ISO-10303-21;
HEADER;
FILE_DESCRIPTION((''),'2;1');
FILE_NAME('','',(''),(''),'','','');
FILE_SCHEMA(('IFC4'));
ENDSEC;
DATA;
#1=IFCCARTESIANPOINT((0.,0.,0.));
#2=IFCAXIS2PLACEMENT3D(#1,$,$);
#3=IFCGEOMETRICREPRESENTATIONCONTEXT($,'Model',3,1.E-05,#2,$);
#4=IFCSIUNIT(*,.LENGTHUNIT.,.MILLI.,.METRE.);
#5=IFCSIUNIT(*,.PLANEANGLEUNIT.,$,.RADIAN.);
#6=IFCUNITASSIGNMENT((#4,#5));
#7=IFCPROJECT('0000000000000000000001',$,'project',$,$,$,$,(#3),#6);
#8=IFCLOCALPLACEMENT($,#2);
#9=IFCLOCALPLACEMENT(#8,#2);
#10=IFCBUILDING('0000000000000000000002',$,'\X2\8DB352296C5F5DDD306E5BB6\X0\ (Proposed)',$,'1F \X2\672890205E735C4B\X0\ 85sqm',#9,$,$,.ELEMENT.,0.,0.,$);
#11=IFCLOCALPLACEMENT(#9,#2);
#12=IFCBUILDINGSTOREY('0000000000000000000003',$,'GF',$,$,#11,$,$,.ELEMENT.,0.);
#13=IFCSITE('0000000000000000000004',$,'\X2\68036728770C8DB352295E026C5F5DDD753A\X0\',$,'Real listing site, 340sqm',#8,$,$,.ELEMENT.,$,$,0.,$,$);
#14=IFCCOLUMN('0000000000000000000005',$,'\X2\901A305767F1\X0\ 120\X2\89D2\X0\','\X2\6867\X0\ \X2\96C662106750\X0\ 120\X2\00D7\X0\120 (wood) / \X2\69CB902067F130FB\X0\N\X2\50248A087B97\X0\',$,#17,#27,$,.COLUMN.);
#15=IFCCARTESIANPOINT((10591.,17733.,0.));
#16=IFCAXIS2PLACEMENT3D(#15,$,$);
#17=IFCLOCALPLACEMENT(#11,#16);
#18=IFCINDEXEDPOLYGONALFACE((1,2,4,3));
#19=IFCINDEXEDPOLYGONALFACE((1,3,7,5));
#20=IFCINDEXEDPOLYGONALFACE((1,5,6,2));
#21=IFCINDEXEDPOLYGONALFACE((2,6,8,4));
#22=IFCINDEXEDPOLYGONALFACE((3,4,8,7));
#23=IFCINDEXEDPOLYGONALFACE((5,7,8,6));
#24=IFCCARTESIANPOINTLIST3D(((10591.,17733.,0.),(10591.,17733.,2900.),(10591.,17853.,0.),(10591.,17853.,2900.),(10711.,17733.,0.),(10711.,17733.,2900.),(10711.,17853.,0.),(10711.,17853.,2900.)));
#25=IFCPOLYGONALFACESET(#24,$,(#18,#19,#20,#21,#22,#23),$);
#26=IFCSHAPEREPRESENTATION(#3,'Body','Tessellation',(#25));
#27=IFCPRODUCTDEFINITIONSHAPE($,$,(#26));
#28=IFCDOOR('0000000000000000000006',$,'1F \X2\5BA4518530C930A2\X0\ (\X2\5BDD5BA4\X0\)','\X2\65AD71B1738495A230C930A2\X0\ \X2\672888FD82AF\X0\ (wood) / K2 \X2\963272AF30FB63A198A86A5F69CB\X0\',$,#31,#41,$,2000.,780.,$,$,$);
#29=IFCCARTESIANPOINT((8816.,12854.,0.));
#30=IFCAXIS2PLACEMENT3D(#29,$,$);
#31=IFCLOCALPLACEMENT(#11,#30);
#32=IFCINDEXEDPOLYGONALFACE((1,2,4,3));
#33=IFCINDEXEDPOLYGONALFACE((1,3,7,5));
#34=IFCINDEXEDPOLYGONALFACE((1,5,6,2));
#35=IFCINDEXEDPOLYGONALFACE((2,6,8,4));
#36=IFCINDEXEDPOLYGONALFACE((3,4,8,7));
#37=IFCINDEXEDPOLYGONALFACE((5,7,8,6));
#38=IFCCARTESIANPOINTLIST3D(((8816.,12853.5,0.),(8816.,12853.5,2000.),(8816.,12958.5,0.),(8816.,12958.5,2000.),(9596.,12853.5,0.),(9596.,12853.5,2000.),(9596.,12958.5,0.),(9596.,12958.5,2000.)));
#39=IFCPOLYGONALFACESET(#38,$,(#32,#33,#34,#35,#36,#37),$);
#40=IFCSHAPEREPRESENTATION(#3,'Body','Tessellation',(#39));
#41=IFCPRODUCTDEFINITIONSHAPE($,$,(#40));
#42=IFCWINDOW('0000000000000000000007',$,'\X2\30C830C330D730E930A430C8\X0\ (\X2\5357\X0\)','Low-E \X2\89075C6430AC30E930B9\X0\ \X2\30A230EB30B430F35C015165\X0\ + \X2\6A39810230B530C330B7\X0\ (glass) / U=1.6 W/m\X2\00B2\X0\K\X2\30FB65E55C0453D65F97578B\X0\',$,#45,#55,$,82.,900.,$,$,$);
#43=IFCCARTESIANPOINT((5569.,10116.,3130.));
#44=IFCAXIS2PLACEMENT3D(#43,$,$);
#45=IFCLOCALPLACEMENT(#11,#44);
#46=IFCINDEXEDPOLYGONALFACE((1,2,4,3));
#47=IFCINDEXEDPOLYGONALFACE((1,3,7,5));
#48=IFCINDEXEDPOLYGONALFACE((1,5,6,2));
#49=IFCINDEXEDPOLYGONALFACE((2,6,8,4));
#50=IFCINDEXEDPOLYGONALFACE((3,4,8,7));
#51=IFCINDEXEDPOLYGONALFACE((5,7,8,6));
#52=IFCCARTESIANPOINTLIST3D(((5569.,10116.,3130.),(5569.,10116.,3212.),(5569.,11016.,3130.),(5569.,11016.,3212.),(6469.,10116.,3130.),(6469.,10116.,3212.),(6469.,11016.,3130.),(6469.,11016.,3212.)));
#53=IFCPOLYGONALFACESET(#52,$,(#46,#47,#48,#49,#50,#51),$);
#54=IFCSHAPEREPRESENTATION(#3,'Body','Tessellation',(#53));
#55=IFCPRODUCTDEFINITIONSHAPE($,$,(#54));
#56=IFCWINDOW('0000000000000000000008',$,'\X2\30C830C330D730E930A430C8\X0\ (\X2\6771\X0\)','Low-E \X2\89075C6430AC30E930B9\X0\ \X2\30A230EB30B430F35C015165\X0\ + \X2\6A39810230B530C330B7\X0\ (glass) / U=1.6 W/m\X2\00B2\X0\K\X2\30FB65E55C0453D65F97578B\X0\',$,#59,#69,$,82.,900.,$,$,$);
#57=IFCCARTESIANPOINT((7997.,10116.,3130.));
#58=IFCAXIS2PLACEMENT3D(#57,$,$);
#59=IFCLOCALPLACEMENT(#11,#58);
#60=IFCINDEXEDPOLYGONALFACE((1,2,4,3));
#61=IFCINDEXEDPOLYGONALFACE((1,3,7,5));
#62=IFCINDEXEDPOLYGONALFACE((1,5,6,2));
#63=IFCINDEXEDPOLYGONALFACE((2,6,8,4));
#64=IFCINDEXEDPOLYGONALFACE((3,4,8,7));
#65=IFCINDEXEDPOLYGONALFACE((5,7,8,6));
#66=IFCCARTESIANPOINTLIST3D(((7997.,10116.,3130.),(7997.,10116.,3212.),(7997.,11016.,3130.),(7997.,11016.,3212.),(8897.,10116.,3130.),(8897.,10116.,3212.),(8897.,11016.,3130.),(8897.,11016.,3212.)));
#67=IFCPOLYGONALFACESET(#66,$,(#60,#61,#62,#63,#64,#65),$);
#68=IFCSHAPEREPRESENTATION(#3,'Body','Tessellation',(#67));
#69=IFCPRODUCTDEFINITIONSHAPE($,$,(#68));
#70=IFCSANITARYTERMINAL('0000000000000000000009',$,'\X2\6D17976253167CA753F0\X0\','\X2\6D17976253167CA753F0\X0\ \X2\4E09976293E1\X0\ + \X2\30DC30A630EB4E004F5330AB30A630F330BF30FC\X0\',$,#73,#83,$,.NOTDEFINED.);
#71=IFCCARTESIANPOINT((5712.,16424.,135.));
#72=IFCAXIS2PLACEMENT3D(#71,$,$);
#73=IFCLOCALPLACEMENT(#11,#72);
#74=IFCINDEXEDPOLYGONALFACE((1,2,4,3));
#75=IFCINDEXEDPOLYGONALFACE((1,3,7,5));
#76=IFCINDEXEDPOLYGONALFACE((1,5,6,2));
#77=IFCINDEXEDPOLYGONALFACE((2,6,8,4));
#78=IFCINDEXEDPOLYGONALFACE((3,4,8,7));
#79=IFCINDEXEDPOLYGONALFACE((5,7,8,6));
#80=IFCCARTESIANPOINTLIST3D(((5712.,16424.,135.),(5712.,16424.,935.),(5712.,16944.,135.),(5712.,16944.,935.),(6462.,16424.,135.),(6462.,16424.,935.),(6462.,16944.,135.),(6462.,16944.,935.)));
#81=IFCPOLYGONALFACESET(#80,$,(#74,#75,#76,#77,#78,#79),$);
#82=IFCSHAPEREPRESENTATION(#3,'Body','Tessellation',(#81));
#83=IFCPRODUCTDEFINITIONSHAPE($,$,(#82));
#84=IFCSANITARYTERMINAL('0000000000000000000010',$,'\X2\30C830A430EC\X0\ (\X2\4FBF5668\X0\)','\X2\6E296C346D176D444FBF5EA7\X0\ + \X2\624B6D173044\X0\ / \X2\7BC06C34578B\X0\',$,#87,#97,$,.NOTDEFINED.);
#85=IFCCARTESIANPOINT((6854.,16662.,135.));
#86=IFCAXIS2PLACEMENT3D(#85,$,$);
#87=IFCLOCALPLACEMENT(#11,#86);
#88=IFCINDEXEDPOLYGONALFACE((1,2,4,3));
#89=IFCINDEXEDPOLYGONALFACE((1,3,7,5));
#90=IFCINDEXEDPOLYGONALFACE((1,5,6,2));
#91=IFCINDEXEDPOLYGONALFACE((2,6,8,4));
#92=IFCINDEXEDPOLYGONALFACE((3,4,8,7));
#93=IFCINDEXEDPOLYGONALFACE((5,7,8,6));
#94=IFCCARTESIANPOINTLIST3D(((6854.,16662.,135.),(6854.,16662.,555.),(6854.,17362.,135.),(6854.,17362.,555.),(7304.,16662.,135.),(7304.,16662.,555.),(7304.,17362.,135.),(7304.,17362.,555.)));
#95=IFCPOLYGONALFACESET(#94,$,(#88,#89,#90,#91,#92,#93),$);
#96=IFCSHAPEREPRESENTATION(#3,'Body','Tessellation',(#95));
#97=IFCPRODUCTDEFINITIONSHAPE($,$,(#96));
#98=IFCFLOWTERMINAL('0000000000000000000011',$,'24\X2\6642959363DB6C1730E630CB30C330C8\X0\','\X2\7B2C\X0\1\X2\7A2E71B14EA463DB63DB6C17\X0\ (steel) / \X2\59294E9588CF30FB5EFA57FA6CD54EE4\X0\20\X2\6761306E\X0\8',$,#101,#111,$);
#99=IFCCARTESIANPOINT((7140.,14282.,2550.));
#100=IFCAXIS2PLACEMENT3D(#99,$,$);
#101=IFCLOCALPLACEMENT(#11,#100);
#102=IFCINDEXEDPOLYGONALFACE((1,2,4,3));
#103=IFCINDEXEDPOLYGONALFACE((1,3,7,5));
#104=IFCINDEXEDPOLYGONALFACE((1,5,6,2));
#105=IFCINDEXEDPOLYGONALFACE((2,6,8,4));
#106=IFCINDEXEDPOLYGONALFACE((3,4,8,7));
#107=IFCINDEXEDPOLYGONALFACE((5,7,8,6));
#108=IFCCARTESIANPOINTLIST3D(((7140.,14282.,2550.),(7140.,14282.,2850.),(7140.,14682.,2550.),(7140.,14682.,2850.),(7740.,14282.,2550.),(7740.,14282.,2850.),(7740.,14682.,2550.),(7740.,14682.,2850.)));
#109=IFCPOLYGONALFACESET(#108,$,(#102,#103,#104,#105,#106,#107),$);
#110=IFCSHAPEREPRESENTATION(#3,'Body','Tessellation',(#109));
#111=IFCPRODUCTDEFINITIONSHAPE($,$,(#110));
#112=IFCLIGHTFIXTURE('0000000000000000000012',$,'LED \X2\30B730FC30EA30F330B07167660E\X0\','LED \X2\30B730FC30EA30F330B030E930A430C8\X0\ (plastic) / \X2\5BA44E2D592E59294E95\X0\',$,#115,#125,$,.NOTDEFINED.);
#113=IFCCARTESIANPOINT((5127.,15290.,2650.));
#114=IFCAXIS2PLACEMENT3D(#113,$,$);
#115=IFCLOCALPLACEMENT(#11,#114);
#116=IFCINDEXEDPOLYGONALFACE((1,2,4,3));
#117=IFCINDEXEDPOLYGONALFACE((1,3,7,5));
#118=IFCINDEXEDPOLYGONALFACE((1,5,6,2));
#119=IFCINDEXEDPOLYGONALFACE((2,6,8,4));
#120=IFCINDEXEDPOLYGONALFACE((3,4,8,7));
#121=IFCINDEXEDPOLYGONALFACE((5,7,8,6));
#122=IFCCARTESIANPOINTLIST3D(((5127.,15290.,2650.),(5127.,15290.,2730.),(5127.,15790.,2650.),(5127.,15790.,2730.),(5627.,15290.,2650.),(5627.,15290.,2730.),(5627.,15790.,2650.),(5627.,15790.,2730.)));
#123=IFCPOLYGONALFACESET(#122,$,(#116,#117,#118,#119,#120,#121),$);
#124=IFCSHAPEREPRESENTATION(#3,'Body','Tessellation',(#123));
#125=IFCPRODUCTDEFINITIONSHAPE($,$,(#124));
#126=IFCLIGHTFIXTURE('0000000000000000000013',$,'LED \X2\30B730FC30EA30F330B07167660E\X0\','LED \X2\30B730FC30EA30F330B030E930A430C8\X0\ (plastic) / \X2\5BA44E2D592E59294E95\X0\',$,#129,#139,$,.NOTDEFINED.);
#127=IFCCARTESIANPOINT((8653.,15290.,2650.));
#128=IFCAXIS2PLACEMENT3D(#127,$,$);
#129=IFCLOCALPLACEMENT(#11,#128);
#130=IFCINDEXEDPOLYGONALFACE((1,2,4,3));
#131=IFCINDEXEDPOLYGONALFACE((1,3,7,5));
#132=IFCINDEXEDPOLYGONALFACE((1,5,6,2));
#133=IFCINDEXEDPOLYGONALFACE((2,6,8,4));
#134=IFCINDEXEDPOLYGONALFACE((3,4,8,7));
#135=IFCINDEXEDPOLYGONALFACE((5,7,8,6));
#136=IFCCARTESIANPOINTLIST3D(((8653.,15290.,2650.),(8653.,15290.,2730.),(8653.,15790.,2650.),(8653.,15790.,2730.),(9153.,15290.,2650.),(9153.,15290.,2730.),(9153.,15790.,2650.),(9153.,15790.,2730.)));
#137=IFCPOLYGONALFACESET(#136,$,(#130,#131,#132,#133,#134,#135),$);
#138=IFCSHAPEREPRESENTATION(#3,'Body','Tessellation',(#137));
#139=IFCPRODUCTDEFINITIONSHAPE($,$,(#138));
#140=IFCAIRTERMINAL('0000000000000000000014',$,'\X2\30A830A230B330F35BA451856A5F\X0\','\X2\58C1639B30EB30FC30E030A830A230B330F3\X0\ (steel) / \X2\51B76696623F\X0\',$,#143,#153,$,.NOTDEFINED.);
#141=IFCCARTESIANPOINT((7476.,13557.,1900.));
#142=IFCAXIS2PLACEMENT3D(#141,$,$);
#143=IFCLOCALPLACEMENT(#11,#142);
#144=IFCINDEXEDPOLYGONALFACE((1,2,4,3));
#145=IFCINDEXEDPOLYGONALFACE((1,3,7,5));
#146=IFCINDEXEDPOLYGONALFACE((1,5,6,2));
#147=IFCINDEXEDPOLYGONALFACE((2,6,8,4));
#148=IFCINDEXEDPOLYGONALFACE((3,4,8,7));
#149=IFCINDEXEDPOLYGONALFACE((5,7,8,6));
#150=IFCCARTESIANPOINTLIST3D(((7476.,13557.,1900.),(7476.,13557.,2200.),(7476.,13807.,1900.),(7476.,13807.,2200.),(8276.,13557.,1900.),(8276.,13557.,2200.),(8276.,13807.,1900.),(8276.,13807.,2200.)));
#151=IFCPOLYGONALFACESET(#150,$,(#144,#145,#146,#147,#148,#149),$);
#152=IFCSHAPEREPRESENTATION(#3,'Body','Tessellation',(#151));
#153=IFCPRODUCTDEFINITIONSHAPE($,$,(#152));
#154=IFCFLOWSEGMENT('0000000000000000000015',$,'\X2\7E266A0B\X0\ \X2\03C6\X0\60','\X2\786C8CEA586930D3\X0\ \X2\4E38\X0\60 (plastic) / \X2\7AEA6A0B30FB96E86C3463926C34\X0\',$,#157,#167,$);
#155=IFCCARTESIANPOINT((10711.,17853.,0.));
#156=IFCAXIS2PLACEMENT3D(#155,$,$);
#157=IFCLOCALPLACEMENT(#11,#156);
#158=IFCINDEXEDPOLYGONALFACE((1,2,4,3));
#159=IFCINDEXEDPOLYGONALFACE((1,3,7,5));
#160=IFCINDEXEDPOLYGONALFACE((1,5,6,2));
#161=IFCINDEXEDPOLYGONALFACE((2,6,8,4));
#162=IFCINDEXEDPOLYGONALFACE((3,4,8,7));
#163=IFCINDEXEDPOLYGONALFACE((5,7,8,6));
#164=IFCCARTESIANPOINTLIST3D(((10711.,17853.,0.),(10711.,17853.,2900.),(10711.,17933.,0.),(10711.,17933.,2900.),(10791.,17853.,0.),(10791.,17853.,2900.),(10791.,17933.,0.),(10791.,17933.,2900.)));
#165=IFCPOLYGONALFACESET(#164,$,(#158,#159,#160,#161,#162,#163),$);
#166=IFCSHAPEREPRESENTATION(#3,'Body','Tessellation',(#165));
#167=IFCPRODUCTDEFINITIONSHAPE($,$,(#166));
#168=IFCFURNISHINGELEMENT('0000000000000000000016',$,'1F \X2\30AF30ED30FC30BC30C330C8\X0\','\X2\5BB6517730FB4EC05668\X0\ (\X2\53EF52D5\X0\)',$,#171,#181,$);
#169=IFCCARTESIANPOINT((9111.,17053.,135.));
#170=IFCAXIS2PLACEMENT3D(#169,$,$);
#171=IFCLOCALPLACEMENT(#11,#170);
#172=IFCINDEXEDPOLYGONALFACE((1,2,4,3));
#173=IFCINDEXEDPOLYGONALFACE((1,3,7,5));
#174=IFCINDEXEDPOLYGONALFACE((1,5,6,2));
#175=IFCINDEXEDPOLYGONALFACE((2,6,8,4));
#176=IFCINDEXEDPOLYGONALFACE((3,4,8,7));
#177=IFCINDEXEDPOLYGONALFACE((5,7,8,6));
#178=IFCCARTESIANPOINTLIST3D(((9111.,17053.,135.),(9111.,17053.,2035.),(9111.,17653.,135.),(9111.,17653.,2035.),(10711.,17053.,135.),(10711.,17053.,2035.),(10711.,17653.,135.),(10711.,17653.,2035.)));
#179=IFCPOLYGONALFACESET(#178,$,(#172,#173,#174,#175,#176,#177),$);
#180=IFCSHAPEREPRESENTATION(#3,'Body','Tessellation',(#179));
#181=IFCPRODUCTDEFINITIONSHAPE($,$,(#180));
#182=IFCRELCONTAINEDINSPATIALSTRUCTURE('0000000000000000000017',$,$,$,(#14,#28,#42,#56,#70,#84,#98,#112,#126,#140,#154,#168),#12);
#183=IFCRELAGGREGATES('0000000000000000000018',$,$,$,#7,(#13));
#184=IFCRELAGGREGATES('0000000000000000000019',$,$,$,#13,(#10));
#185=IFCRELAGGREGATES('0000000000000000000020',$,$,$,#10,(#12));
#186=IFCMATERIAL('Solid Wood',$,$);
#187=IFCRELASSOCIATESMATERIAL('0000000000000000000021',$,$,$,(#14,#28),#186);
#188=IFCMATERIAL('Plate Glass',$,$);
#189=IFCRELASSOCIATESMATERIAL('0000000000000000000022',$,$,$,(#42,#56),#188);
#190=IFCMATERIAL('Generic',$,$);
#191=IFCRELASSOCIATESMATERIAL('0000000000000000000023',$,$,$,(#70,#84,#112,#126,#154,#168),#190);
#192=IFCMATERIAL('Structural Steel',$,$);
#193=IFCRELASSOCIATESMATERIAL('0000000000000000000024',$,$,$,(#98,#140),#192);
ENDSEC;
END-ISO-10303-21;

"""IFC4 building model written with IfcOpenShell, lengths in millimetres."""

from ifc_helpers import new_model, si_unit, frame, frame_2d, origin, place, context, project, spatial, rectangle, extrude, material, element, save


model = new_model("IFC4")

# Units and contexts
model_context = context("Model", 3, precision=1e-05, world=origin())
ifc_project = project(units=[si_unit("LENGTHUNIT", "METRE", prefix="MILLI"), si_unit("PLANEANGLEUNIT", "RADIAN")], contexts=[model_context])

# Site, building, storey
site_placement = place(None, origin())
site = spatial("IfcSite", under=ifc_project, at=site_placement, Name="栃木県足利市江川町", ObjectType="Real listing site, 340sqm", CompositionType="ELEMENT", RefElevation=0.0)
building_placement = place(site_placement, origin())
building = spatial("IfcBuilding", under=site, at=building_placement, Name="足利江川の家 (Proposed)", ObjectType="1F 木造平屋 85sqm", CompositionType="ELEMENT", ElevationOfRefHeight=0.0, ElevationOfTerrain=0.0)
storey_placement = place(building_placement, origin())
storey = spatial("IfcBuildingStorey", under=building, at=storey_placement, Name="GF", CompositionType="ELEMENT", Elevation=0.0)

# Column
ifc_material_1 = material(Name="Solid Wood")
column_1_placement = place(storey_placement, frame((10591.0, 17733.0, 0.0)))
element("IfcColumn", 1, at=column_1_placement, inside=storey, material=ifc_material_1, Name="通し柱 120角", Description="桧 集成材 120×120 (wood) / 構造柱・N値計算", PredefinedType="COLUMN", context=model_context, shape_type="SweptSolid", body=[
    extrude(rectangle(XDim=120.0, YDim=120.0, at=frame_2d((60.0, 60.0))), frame((10591.0, 17733.0, 0.0)), (0.0, 0.0, 1.0), 2900.0),
])

# Door
door_placement = place(storey_placement, frame((8816.0, 12854.0, 0.0)))
element("IfcDoor", 2, at=door_placement, inside=storey, material=ifc_material_1, Name="1F 室内ドア (寝室)", Description="断熱玄関ドア 木製芯 (wood) / K2 防犯・採風機構", OverallHeight=2000.0, OverallWidth=780.0, context=model_context, shape_type="SweptSolid", body=[
    extrude(rectangle(XDim=780.0, YDim=105.0, at=frame_2d((390.0, 52.0))), frame((8816.0, 12854.0, 0.0)), (0.0, 0.0, 1.0), 2000.0),
])

# Windows
ifc_material_2 = material(Name="Plate Glass")
window_1_placement = place(storey_placement, frame((5569.0, 10116.0, 3130.0)))
element("IfcWindow", 3, at=window_1_placement, inside=storey, material=ifc_material_2, Name="トップライト (南)", Description="Low-E 複層ガラス アルゴン封入 + 樹脂サッシ (glass) / U=1.6 W/m²K・日射取得型", OverallHeight=82.0, OverallWidth=900.0, context=model_context, shape_type="SweptSolid", body=[
    extrude(rectangle(XDim=900.0, YDim=900.0, at=frame_2d((450.0, 450.0))), frame((5569.0, 10116.0, 3130.0)), (0.0, 0.0, 1.0), 82.0),
])
window_2_placement = place(storey_placement, frame((7997.0, 10116.0, 3130.0)))
element("IfcWindow", 4, at=window_2_placement, inside=storey, material=ifc_material_2, Name="トップライト (東)", Description="Low-E 複層ガラス アルゴン封入 + 樹脂サッシ (glass) / U=1.6 W/m²K・日射取得型", OverallHeight=82.0, OverallWidth=900.0, context=model_context, shape_type="SweptSolid", body=[
    extrude(rectangle(XDim=900.0, YDim=900.0, at=frame_2d((450.0, 450.0))), frame((7997.0, 10116.0, 3130.0)), (0.0, 0.0, 1.0), 82.0),
])

# Sanitary terminals
ifc_material_3 = material(Name="Generic")
sanitary_terminal_1_placement = place(storey_placement, frame((5712.0, 16424.0, 135.0)))
element("IfcSanitaryTerminal", 5, at=sanitary_terminal_1_placement, inside=storey, material=ifc_material_3, Name="洗面化粧台", Description="洗面化粧台 三面鏡 + ボウル一体カウンター", PredefinedType="NOTDEFINED", context=model_context, shape_type="SweptSolid", body=[
    extrude(rectangle(XDim=750.0, YDim=520.0, at=frame_2d((375.0, 260.0))), frame((5712.0, 16424.0, 135.0)), (0.0, 0.0, 1.0), 800.0),
])
sanitary_terminal_2_placement = place(storey_placement, frame((6854.0, 16662.0, 135.0)))
element("IfcSanitaryTerminal", 6, at=sanitary_terminal_2_placement, inside=storey, material=ifc_material_3, Name="トイレ (便器)", Description="温水洗浄便座 + 手洗い / 節水型", PredefinedType="NOTDEFINED", context=model_context, shape_type="SweptSolid", body=[
    extrude(rectangle(XDim=450.0, YDim=700.0, at=frame_2d((225.0, 350.0))), frame((6854.0, 16662.0, 135.0)), (0.0, 0.0, 1.0), 420.0),
])

# Flow terminal
ifc_material_4 = material(Name="Structural Steel")
flow_terminal_placement = place(storey_placement, frame((7140.0, 14282.0, 2550.0)))
element("IfcFlowTerminal", 7, at=flow_terminal_placement, inside=storey, material=ifc_material_4, Name="24時間換気ユニット", Description="第1種熱交換換気 (steel) / 天井裏・建基法令20条の8", context=model_context, shape_type="SweptSolid", body=[
    extrude(rectangle(XDim=600.0, YDim=400.0, at=frame_2d((300.0, 200.0))), frame((7140.0, 14282.0, 2550.0)), (0.0, 0.0, 1.0), 300.0),
])

# Light fixtures
light_fixture_1_placement = place(storey_placement, frame((5127.0, 15290.0, 2650.0)))
element("IfcLightFixture", 8, at=light_fixture_1_placement, inside=storey, material=ifc_material_3, Name="LED シーリング照明", Description="LED シーリングライト (plastic) / 室中央天井", PredefinedType="NOTDEFINED", context=model_context, shape_type="SweptSolid", body=[
    extrude(rectangle(XDim=500.0, YDim=500.0, at=frame_2d((250.0, 250.0))), frame((5127.0, 15290.0, 2650.0)), (0.0, 0.0, 1.0), 80.0),
])
light_fixture_2_placement = place(storey_placement, frame((8653.0, 15290.0, 2650.0)))
element("IfcLightFixture", 9, at=light_fixture_2_placement, inside=storey, material=ifc_material_3, Name="LED シーリング照明", Description="LED シーリングライト (plastic) / 室中央天井", PredefinedType="NOTDEFINED", context=model_context, shape_type="SweptSolid", body=[
    extrude(rectangle(XDim=500.0, YDim=500.0, at=frame_2d((250.0, 250.0))), frame((8653.0, 15290.0, 2650.0)), (0.0, 0.0, 1.0), 80.0),
])

# Air terminal
air_terminal_placement = place(storey_placement, frame((7476.0, 13557.0, 1900.0)))
element("IfcAirTerminal", 10, at=air_terminal_placement, inside=storey, material=ifc_material_4, Name="エアコン室内機", Description="壁掛ルームエアコン (steel) / 冷暖房", PredefinedType="NOTDEFINED", context=model_context, shape_type="SweptSolid", body=[
    extrude(rectangle(XDim=800.0, YDim=250.0, at=frame_2d((400.0, 125.0))), frame((7476.0, 13557.0, 1900.0)), (0.0, 0.0, 1.0), 300.0),
])

# Flow segment
flow_segment_placement = place(storey_placement, frame((10711.0, 17853.0, 0.0)))
element("IfcFlowSegment", 11, at=flow_segment_placement, inside=storey, material=ifc_material_3, Name="縦樋 φ60", Description="硬質塩ビ 丸60 (plastic) / 竪樋・雨水排水", context=model_context, shape_type="SweptSolid", body=[
    extrude(rectangle(XDim=80.0, YDim=80.0, at=frame_2d((40.0, 40.0))), frame((10711.0, 17853.0, 0.0)), (0.0, 0.0, 1.0), 2900.0),
])

# Furnishing element
furnishing_placement = place(storey_placement, frame((9111.0, 17053.0, 135.0)))
element("IfcFurnishingElement", 12, at=furnishing_placement, inside=storey, material=ifc_material_3, Name="1F クローゼット", Description="家具・什器 (可動)", context=model_context, shape_type="SweptSolid", body=[
    extrude(rectangle(XDim=1600.0, YDim=600.0, at=frame_2d((800.0, 300.0))), frame((9111.0, 17053.0, 135.0)), (0.0, 0.0, 1.0), 1900.0),
])

save(model, "model.ifc")
